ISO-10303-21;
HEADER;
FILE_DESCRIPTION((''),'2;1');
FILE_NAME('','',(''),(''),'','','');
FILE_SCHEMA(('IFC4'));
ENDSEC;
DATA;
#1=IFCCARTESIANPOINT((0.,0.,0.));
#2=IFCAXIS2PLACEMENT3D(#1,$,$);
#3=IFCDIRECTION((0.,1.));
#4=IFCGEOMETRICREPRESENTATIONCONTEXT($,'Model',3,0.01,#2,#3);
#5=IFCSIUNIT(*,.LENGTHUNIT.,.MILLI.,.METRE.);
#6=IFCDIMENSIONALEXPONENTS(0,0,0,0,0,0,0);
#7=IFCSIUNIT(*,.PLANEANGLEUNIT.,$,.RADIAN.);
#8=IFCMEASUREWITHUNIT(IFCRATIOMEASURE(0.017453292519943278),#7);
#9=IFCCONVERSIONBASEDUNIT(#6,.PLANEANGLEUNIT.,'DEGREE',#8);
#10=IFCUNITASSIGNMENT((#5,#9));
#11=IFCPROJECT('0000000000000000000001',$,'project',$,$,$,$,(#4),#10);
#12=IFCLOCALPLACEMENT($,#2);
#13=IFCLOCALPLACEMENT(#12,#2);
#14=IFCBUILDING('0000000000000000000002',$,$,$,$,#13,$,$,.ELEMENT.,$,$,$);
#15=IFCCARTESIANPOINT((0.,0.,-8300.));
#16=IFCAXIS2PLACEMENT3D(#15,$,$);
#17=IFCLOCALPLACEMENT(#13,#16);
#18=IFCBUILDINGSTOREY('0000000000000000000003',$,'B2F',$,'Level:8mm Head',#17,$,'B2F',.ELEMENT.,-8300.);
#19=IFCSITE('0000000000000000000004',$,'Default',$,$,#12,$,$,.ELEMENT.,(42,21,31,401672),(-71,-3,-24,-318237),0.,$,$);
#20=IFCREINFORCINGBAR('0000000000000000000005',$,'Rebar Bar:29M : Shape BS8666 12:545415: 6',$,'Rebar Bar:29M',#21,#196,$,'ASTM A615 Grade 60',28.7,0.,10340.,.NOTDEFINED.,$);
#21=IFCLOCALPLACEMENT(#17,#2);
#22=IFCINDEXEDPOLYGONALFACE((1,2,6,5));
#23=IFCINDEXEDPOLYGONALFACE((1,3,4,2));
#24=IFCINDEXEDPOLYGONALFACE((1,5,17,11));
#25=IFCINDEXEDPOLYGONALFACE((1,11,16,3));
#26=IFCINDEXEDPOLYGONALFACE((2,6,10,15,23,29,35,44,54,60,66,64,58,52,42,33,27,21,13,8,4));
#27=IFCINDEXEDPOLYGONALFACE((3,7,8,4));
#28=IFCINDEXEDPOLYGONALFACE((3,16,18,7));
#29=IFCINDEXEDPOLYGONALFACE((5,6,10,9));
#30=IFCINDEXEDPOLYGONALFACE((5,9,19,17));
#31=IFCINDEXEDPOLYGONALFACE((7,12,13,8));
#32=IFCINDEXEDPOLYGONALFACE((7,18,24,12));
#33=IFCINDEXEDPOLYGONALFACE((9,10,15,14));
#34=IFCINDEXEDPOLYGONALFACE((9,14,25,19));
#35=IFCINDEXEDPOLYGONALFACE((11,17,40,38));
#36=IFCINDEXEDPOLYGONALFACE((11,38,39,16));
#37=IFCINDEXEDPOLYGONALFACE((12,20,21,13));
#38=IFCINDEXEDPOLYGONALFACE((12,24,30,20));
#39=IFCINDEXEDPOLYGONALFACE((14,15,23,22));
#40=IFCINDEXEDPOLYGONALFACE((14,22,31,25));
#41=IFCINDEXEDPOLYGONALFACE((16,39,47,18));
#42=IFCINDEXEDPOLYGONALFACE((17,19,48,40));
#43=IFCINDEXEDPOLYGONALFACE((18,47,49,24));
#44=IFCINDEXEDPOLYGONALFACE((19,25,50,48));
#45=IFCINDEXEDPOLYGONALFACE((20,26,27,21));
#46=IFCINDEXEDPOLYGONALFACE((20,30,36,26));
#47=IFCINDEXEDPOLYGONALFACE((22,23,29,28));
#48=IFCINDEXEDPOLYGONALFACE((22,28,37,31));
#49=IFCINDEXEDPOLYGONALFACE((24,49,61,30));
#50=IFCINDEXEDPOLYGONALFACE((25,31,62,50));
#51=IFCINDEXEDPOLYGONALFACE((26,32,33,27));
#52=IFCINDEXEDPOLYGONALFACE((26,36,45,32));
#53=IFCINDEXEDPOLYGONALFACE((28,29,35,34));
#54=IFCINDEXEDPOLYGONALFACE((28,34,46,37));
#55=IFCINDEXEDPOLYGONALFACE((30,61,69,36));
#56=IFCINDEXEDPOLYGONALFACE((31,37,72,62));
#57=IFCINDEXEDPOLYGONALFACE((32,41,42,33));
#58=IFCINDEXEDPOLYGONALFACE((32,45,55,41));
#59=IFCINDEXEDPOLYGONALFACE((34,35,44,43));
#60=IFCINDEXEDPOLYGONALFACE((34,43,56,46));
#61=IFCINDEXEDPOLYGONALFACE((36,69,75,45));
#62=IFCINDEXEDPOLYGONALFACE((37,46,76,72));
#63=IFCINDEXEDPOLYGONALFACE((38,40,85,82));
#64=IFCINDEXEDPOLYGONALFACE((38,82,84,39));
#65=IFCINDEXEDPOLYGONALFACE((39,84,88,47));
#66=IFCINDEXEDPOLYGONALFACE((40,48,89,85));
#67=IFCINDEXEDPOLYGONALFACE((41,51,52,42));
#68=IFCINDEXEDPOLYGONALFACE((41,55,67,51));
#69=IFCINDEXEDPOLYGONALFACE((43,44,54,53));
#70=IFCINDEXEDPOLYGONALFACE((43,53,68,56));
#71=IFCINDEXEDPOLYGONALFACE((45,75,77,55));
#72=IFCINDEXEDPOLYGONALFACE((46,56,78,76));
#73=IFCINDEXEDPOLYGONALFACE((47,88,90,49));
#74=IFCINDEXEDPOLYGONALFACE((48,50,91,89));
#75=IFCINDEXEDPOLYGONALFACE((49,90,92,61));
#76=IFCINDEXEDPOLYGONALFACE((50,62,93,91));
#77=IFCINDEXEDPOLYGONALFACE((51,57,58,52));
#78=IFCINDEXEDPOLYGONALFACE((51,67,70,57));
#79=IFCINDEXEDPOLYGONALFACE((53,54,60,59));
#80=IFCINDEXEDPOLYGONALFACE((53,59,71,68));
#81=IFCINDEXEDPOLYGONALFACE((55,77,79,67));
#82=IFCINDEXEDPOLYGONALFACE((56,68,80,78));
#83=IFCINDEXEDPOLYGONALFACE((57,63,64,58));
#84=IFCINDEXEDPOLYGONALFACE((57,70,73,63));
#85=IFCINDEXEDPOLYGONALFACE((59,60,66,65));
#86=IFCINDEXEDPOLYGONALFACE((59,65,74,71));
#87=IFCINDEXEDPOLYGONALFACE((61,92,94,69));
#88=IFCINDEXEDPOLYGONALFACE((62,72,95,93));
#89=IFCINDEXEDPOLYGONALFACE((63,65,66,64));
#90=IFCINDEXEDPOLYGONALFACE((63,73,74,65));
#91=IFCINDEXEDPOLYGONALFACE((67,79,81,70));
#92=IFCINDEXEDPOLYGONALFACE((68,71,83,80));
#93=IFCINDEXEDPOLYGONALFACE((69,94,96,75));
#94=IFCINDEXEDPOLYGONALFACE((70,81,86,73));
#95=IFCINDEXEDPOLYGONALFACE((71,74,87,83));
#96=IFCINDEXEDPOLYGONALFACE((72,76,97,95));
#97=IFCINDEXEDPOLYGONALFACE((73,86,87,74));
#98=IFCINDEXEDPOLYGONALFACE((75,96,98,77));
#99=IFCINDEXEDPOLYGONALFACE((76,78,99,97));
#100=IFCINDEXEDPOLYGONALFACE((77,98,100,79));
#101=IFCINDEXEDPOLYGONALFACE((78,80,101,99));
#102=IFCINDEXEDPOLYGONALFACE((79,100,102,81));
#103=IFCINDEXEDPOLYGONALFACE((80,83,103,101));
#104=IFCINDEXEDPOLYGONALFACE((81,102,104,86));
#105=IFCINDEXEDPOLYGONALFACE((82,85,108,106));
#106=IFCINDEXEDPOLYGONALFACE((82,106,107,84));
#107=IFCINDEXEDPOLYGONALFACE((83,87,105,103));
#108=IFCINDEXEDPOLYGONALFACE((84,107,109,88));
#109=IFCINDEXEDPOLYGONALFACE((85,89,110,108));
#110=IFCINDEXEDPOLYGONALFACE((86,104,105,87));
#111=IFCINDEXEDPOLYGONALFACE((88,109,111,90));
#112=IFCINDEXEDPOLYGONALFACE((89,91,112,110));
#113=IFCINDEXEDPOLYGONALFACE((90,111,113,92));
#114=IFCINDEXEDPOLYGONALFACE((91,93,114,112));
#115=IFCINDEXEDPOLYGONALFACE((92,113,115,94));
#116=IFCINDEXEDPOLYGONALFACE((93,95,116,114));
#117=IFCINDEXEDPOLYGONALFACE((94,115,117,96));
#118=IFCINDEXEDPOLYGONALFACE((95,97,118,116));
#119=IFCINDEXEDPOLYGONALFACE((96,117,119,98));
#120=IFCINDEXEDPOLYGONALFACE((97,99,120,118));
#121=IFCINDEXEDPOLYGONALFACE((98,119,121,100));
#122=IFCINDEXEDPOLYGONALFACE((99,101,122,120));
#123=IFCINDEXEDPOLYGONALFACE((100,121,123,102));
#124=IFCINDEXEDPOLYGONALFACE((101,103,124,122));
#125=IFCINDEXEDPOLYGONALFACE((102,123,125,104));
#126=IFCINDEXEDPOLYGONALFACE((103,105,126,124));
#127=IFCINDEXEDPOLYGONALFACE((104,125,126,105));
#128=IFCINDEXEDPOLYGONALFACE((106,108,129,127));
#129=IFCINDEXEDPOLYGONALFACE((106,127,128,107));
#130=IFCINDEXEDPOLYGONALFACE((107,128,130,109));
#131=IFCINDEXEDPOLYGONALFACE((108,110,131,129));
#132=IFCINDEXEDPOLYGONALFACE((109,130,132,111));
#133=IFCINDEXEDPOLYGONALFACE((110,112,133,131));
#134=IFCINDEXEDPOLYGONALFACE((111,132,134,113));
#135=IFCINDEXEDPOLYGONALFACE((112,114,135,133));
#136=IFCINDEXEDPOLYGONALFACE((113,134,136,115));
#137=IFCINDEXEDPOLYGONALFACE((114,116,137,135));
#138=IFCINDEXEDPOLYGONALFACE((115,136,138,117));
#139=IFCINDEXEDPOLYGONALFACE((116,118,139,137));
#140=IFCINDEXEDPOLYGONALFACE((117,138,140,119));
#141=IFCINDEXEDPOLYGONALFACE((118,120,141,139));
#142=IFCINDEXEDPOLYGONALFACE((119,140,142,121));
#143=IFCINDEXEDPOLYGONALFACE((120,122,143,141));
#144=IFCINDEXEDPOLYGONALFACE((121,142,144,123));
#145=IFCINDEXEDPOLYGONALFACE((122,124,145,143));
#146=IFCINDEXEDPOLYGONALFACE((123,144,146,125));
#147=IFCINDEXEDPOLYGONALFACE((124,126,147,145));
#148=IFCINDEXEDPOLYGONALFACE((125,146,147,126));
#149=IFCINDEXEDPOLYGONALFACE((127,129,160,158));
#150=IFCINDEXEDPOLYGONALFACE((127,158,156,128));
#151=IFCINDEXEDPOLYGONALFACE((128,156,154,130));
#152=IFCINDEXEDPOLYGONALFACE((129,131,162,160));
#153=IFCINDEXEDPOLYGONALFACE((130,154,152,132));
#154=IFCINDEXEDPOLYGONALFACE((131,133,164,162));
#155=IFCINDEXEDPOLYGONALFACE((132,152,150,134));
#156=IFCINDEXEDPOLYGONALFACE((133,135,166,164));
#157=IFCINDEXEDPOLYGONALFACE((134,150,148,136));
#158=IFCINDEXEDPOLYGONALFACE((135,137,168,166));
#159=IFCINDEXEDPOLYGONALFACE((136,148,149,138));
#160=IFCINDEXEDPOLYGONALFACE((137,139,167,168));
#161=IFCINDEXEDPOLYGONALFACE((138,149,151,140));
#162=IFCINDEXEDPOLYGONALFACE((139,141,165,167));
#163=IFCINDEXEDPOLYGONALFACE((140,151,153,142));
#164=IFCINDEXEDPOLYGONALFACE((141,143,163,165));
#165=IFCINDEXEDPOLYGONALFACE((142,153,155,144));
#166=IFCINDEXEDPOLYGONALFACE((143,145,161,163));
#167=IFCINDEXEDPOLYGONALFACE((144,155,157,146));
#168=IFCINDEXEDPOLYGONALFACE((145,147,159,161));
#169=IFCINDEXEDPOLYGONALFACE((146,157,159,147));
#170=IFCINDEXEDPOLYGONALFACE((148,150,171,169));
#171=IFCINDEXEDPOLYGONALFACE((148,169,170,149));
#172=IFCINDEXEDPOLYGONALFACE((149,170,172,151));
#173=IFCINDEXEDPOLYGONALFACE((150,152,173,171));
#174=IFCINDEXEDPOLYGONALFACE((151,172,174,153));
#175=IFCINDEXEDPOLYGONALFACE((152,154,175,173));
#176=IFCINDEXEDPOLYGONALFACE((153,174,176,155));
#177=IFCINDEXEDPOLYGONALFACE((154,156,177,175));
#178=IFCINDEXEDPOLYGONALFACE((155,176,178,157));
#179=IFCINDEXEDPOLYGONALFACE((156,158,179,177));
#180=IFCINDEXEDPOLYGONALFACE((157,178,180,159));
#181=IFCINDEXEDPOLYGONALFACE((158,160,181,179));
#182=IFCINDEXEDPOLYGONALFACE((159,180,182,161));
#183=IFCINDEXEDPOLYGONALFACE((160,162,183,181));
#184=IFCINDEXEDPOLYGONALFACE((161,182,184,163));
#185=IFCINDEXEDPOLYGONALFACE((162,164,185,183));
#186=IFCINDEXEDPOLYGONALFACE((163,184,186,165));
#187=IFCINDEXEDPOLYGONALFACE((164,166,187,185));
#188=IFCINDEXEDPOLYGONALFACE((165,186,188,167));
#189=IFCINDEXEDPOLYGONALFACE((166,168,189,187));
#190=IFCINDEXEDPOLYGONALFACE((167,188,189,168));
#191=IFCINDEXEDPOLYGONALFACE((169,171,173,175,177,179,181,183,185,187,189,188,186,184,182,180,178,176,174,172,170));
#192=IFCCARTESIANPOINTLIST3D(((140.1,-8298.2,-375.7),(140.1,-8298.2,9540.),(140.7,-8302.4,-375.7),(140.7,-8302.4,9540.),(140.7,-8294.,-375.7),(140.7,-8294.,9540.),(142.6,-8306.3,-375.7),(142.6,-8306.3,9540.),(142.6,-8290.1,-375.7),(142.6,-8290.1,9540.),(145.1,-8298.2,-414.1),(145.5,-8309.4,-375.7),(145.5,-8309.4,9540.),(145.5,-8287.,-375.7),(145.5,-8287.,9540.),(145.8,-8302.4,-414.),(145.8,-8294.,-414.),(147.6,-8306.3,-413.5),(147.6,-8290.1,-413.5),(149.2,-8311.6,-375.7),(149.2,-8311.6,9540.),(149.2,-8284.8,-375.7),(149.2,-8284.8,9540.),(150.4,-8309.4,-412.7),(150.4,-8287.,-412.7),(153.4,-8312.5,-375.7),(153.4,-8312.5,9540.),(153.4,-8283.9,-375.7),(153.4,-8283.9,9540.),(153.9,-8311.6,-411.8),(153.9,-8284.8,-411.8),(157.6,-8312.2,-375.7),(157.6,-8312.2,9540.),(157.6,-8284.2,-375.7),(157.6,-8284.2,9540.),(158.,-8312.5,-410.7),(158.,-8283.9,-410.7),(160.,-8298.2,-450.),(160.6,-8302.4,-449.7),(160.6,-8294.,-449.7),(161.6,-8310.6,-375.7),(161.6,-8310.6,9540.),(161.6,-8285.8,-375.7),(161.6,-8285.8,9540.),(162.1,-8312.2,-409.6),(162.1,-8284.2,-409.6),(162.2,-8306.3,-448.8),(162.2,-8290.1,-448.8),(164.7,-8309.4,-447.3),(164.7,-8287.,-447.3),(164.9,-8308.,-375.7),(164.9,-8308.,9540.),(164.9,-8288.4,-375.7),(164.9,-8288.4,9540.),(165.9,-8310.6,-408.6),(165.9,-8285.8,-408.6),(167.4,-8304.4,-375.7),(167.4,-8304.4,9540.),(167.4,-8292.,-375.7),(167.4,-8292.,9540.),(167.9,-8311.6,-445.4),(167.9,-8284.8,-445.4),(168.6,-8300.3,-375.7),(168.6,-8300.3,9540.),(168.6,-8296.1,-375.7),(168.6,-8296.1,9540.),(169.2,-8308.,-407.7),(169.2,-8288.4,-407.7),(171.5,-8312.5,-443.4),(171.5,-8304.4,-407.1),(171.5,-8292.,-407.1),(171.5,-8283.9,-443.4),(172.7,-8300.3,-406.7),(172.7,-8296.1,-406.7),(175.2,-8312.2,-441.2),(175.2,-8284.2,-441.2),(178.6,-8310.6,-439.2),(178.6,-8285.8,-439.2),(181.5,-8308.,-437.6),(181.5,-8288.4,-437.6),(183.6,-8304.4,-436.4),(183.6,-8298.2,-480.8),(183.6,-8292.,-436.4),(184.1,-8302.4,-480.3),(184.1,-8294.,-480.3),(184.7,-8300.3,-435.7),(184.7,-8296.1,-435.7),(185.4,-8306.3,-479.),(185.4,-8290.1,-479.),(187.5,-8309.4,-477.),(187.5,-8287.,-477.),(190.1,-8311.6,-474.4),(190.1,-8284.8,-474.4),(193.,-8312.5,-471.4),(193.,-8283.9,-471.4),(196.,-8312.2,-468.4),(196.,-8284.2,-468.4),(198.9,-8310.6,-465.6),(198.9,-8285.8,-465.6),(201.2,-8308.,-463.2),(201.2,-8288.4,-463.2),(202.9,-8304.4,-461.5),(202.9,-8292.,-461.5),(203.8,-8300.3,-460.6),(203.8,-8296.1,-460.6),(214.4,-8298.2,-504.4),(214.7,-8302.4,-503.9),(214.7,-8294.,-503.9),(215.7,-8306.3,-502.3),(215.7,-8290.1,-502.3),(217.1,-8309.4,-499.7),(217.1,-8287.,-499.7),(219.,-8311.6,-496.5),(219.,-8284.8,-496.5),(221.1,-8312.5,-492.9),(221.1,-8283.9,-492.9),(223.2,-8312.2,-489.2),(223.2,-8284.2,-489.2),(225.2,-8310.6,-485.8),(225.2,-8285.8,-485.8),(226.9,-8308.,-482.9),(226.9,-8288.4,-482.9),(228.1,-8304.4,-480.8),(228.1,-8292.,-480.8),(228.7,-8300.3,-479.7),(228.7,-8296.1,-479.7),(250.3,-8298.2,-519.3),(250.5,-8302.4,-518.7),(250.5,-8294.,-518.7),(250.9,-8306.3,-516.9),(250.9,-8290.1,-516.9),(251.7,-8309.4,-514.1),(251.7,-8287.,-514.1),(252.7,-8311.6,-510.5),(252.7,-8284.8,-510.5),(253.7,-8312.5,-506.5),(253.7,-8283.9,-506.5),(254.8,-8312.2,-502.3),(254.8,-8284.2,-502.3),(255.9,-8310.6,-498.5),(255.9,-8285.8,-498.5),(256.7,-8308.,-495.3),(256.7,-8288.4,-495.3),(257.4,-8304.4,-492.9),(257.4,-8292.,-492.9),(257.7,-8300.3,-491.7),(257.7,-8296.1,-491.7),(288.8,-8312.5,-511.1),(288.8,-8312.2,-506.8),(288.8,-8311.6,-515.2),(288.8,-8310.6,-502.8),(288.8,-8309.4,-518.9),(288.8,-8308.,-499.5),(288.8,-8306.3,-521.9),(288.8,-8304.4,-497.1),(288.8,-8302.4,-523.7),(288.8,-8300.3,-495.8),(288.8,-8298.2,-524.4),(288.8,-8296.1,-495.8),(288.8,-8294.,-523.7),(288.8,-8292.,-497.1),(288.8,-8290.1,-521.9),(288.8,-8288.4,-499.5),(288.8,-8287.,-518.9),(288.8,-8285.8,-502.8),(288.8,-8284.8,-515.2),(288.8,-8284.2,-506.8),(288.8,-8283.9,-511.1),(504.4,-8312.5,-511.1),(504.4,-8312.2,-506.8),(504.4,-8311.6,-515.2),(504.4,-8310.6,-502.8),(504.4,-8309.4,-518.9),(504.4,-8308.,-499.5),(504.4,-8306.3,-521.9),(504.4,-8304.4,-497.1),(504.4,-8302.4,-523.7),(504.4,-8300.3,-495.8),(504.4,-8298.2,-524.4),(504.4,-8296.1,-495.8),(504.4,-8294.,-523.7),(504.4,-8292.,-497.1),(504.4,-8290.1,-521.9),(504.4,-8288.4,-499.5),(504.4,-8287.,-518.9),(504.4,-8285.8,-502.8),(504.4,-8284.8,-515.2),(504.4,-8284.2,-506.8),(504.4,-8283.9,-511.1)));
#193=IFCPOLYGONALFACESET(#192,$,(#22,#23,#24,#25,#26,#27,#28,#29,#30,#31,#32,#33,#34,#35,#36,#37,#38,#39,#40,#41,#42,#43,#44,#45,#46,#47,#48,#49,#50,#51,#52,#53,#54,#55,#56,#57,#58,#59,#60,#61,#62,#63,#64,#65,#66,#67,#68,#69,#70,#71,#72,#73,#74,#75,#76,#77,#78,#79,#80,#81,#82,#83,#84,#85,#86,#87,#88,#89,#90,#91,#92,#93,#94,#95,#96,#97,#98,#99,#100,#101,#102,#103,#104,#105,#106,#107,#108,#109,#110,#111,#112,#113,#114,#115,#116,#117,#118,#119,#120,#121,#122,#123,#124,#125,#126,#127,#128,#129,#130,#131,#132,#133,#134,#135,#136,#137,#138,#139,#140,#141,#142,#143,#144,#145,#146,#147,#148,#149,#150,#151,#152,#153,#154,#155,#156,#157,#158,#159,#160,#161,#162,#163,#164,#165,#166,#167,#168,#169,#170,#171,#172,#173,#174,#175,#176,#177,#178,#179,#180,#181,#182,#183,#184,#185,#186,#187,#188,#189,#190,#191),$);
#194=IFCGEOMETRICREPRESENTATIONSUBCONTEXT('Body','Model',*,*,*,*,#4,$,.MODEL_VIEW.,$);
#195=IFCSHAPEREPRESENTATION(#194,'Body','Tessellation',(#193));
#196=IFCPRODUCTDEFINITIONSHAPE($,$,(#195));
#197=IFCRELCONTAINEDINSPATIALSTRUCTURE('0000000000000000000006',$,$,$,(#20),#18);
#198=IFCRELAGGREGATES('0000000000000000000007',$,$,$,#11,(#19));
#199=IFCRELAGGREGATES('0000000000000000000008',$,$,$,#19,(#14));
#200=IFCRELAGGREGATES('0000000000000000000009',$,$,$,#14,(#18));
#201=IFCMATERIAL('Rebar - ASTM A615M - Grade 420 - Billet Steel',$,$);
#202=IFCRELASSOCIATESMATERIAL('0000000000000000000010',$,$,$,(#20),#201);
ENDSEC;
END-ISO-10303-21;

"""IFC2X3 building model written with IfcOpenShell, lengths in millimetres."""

from ifc_helpers import new_model, entity, si_unit, converted_unit, direction, frame, origin, place, context, subcontext, project, spatial, material, element, save


model = new_model("IFC2X3")

# Units and contexts
model_context = context("Model", 3, precision=0.01, world=origin(), true_north=direction((0.0, 1.0)))
body_context = subcontext(model_context, "Body", "Model", "MODEL_VIEW")
ifc_project = project(units=[si_unit("LENGTHUNIT", "METRE", prefix="MILLI"), converted_unit("PLANEANGLEUNIT", "DEGREE", entity("IfcRatioMeasure", 0.017453292519943278), si_unit("PLANEANGLEUNIT", "RADIAN"), dimensions=[0, 0, 0, 0, 0, 0, 0])], contexts=[model_context])

# Site, building, storey
site_placement = place(None, origin())
site = spatial("IfcSite", under=ifc_project, at=site_placement, Name="Default", CompositionType="ELEMENT", RefLatitude=(42, 21, 31, 401672), RefLongitude=(-71, -3, -24, -318237), RefElevation=0.0)
building_placement = place(site_placement, origin())
building = spatial("IfcBuilding", under=site, at=building_placement, CompositionType="ELEMENT")
storey_placement = place(building_placement, frame((0.0, 0.0, -8300.0)))
storey = spatial("IfcBuildingStorey", under=building, at=storey_placement, Name="B2F", ObjectType="Level:8mm Head", LongName="B2F", CompositionType="ELEMENT", Elevation=-8300.0)

# Reinforcing bar
ifc_material_1 = material(Name="Rebar - ASTM A615M - Grade 420 - Billet Steel")
reinforcing_bar_1_placement = place(storey_placement, origin())
element("IfcReinforcingBar", 1, at=reinforcing_bar_1_placement, inside=storey, material=ifc_material_1, Name="Rebar Bar:29M : Shape BS8666 12:545415: 6", SteelGrade="ASTM A615 Grade 60", ObjectType="Rebar Bar:29M", BarLength=10340.0, BarRole="NOTDEFINED", CrossSectionArea=0.0, NominalDiameter=28.7, context=body_context, shape_type="AdvancedSweptSolid", body=[
    entity("IfcSweptDiskSolid", entity("IfcCompositeCurve", [entity("IfcCompositeCurveSegment", "CONTINUOUS", True, entity("IfcPolyline", [entity("IfcCartesianPoint", [154.4, -8298.2, 9540.0]), entity("IfcCartesianPoint", [154.4, -8298.2, -375.7])])), entity("IfcCompositeCurveSegment", "CONTINUOUS", True, entity("IfcTrimmedCurve", entity("IfcCircle", entity("IfcAxis2Placement3D", entity("IfcCartesianPoint", [288.8, -8298.2, -375.7]), entity("IfcDirection", [0.0, -1.0, 0.0]), entity("IfcDirection", [0.0, 0.0, -1.0])), 134.3), [entity("IfcParameterValue", 270.0)], [entity("IfcParameterValue", 360.0)], True, "PARAMETER")), entity("IfcCompositeCurveSegment", "CONTINUOUS", True, entity("IfcPolyline", [entity("IfcCartesianPoint", [288.8, -8298.2, -510.0]), entity("IfcCartesianPoint", [504.4, -8298.2, -510.0])]))], False), 14.3, None, 0.0, 92.0),
])

save(model, "model.ifc")
